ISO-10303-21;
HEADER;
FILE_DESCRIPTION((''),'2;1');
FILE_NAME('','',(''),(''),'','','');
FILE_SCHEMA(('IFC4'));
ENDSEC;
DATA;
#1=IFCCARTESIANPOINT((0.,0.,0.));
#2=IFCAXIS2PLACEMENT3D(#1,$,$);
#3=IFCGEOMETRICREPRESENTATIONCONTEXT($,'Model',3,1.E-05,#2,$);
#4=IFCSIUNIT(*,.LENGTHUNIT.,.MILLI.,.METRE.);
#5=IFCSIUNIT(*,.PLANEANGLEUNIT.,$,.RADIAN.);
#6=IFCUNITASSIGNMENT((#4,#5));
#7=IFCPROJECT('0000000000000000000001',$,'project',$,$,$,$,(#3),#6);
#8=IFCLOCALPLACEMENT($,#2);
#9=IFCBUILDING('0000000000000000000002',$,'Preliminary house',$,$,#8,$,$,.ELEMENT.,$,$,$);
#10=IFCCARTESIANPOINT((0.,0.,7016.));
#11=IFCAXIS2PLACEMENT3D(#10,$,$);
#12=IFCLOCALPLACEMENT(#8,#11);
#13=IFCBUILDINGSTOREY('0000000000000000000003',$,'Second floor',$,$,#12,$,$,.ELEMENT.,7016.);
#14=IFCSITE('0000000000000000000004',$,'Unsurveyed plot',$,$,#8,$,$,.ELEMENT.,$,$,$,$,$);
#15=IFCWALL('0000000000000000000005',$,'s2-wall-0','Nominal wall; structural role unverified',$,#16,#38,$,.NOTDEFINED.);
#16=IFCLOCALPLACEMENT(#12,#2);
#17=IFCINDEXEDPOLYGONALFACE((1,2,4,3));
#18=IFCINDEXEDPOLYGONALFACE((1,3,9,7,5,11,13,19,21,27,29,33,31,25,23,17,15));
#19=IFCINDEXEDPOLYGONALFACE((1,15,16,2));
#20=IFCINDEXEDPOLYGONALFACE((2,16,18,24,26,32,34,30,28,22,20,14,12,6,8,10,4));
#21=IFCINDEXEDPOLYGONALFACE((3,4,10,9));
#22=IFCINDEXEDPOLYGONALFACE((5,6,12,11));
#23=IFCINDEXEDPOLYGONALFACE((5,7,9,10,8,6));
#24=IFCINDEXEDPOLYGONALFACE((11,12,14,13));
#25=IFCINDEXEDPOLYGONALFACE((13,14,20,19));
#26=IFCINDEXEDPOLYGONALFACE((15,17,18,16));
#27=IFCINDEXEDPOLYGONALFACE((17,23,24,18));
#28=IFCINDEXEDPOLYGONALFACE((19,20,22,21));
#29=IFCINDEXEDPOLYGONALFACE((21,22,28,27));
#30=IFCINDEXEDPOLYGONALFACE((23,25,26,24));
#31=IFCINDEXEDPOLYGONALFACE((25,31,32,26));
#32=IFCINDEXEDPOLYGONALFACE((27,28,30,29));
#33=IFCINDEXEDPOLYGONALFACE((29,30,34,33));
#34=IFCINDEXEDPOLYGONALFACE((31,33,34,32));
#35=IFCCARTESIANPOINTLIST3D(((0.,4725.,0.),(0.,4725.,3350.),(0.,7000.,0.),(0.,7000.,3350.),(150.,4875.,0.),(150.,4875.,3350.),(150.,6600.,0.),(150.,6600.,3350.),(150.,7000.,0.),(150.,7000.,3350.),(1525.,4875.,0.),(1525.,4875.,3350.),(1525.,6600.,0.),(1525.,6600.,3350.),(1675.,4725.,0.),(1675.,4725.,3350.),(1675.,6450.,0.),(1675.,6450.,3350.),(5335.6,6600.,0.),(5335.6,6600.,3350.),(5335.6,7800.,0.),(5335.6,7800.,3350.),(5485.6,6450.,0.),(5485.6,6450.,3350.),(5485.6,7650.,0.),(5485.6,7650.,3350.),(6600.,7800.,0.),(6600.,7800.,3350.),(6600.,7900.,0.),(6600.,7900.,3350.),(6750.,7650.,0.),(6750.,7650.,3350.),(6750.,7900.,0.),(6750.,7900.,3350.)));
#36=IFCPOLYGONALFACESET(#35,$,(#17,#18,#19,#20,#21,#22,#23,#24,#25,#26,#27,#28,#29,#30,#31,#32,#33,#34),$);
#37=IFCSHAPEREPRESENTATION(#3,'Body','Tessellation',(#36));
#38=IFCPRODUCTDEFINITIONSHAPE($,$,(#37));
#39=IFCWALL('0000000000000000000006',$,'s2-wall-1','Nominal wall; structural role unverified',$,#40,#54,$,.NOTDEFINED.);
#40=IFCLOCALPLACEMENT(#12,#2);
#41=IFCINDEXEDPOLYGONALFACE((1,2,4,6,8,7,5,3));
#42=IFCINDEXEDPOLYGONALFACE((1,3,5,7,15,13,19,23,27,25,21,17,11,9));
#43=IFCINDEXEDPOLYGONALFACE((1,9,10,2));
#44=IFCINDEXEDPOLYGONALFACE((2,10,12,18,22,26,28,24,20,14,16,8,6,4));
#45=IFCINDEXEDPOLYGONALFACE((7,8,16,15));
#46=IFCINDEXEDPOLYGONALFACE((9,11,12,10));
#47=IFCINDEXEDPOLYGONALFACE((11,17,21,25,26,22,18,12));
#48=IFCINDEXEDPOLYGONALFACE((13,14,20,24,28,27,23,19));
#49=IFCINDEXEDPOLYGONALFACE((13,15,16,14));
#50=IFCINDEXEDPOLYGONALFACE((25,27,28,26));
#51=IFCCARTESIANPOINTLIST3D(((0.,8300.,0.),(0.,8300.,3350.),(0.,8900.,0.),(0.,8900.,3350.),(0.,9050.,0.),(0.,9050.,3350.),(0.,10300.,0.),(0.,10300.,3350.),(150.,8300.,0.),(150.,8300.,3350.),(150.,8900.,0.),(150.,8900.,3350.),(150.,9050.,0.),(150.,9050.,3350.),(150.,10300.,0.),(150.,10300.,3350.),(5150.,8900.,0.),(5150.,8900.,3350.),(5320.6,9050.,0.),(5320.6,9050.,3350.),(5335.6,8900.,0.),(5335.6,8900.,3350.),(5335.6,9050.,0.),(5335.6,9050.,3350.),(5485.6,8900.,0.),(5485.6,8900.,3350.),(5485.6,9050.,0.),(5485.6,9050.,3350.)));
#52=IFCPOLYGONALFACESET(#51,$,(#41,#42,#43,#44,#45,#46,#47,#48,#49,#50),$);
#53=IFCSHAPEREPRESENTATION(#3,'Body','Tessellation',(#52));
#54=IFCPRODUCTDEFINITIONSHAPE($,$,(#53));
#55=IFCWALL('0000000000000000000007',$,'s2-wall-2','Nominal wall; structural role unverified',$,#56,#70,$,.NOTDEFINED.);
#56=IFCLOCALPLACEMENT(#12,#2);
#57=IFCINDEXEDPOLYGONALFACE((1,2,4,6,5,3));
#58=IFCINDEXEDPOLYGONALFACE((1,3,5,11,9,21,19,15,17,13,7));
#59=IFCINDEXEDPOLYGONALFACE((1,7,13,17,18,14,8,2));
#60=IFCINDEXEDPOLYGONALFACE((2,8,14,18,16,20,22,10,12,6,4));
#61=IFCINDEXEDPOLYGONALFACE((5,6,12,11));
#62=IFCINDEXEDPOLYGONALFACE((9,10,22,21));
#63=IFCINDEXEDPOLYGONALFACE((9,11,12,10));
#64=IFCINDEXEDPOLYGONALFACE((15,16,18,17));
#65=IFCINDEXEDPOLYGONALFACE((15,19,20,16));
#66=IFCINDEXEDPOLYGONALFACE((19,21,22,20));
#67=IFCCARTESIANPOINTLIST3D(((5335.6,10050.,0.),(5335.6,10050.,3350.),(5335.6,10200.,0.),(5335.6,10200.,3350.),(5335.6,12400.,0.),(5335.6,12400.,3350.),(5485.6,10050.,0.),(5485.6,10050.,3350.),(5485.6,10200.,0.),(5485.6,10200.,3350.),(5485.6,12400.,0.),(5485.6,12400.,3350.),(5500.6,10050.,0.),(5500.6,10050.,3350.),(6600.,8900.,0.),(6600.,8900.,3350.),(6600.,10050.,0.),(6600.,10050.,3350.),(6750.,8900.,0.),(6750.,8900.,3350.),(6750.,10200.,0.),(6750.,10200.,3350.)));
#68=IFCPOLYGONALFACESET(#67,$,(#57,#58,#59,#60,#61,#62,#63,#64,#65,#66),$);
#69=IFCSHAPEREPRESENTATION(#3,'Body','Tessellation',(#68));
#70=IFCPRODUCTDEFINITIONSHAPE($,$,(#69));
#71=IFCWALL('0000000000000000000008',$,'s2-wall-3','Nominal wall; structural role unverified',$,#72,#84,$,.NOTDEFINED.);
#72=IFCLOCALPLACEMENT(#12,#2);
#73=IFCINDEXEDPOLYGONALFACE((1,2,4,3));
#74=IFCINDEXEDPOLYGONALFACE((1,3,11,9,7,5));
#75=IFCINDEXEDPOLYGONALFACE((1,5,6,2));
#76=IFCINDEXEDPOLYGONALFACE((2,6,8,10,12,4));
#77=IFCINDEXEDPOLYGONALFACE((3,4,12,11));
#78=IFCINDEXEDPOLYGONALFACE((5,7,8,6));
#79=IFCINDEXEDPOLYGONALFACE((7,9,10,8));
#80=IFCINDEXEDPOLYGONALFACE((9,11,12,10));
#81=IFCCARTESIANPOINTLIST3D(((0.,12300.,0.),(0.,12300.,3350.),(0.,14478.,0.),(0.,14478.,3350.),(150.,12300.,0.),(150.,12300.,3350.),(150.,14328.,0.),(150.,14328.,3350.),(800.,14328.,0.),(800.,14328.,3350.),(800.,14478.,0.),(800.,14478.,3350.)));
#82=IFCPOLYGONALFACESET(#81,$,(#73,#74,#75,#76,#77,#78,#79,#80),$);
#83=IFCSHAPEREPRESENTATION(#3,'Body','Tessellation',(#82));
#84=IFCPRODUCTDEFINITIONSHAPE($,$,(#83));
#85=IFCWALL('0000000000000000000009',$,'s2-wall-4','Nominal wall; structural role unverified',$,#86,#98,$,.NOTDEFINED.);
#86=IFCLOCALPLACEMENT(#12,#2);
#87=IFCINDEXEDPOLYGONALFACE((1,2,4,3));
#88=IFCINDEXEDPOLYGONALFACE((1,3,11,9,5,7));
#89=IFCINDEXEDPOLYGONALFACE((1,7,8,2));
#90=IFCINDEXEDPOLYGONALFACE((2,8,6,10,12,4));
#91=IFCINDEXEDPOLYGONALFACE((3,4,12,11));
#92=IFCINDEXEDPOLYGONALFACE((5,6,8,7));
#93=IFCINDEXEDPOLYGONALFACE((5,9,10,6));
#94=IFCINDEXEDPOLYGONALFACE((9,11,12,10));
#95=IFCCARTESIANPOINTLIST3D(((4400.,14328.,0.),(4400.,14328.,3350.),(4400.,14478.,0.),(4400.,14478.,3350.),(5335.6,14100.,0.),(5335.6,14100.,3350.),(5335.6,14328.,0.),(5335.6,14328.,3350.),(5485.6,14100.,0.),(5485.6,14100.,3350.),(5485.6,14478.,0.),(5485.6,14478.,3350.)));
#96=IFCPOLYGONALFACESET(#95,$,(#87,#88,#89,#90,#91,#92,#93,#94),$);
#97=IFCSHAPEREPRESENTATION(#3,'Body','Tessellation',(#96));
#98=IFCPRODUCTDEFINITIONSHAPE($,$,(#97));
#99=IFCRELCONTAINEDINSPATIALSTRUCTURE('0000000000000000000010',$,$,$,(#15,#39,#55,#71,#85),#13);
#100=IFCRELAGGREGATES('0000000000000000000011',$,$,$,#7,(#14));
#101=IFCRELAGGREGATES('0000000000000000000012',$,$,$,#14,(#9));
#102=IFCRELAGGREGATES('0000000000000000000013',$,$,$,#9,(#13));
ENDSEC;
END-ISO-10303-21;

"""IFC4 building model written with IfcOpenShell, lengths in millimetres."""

from ifc_helpers import new_model, si_unit, frame, origin, place, context, project, spatial, polyline, outline, extrude, element, save


model = new_model("IFC4")

# Units and contexts
model_context = context("Model", 3, precision=1e-05, world=origin())
ifc_project = project(units=[si_unit("LENGTHUNIT", "METRE", prefix="MILLI"), si_unit("PLANEANGLEUNIT", "RADIAN")], contexts=[model_context])

# Site, building, storey
placement_1 = place(None, origin())
site = spatial("IfcSite", under=ifc_project, at=placement_1, Name="Unsurveyed plot", CompositionType="ELEMENT")
building = spatial("IfcBuilding", under=site, at=placement_1, Name="Preliminary house", CompositionType="ELEMENT")
placement_2 = place(placement_1, frame((0.0, 0.0, 7016.0)))
storey = spatial("IfcBuildingStorey", under=building, at=placement_2, Name="Second floor", CompositionType="ELEMENT", Elevation=7016.0)

# Walls
element("IfcWall", 1, at=placement_2, inside=storey, Name="s2-wall-0", Description="Nominal wall; structural role unverified", PredefinedType="NOTDEFINED", context=model_context, shape_type="SweptSolid", body=[
    extrude(outline(polyline([(0.0, 4725.0), (0.0, 7000.0), (150.0, 7000.0), (150.0, 6600.0), (150.0, 4875.0), (1525.0, 4875.0), (1525.0, 6600.0), (5335.6, 6600.0), (5335.6, 7800.0), (6600.0, 7800.0), (6600.0, 7900.0), (6750.0, 7900.0), (6750.0, 7650.0), (5485.6, 7650.0), (5485.6, 6450.0), (1675.0, 6450.0), (1675.0, 4725.0), (0.0, 4725.0)])), origin(), (0.0, 0.0, 1.0), 3350.0),
])
element("IfcWall", 2, at=placement_2, inside=storey, Name="s2-wall-1", Description="Nominal wall; structural role unverified", PredefinedType="NOTDEFINED", context=model_context, shape_type="SweptSolid", body=[
    extrude(outline(polyline([(0.0, 8900.0), (0.0, 9050.0), (0.0, 10300.0), (150.0, 10300.0), (150.0, 9050.0), (5320.6, 9050.0), (5335.6, 9050.0), (5485.6, 9050.0), (5485.6, 8900.0), (5335.6, 8900.0), (5150.0, 8900.0), (150.0, 8900.0), (150.0, 8300.0), (0.0, 8300.0), (0.0, 8900.0)])), origin(), (0.0, 0.0, 1.0), 3350.0),
])
element("IfcWall", 3, at=placement_2, inside=storey, Name="s2-wall-2", Description="Nominal wall; structural role unverified", PredefinedType="NOTDEFINED", context=model_context, shape_type="SweptSolid", body=[
    extrude(outline(polyline([(5500.6, 10050.0), (5485.6, 10050.0), (5335.6, 10050.0), (5335.6, 10200.0), (5335.6, 12400.0), (5485.6, 12400.0), (5485.6, 10200.0), (6750.0, 10200.0), (6750.0, 8900.0), (6600.0, 8900.0), (6600.0, 10050.0), (5500.6, 10050.0)])), origin(), (0.0, 0.0, 1.0), 3350.0),
])
element("IfcWall", 4, at=placement_2, inside=storey, Name="s2-wall-3", Description="Nominal wall; structural role unverified", PredefinedType="NOTDEFINED", context=model_context, shape_type="SweptSolid", body=[
    extrude(outline(polyline([(800.0, 14328.0), (150.0, 14328.0), (150.0, 12300.0), (0.0, 12300.0), (0.0, 14478.0), (800.0, 14478.0), (800.0, 14328.0)])), origin(), (0.0, 0.0, 1.0), 3350.0),
])
element("IfcWall", 5, at=placement_2, inside=storey, Name="s2-wall-4", Description="Nominal wall; structural role unverified", PredefinedType="NOTDEFINED", context=model_context, shape_type="SweptSolid", body=[
    extrude(outline(polyline([(5335.6, 14328.0), (4400.0, 14328.0), (4400.0, 14478.0), (5485.6, 14478.0), (5485.6, 14100.0), (5335.6, 14100.0), (5335.6, 14328.0)])), origin(), (0.0, 0.0, 1.0), 3350.0),
])

save(model, "model.ifc")
